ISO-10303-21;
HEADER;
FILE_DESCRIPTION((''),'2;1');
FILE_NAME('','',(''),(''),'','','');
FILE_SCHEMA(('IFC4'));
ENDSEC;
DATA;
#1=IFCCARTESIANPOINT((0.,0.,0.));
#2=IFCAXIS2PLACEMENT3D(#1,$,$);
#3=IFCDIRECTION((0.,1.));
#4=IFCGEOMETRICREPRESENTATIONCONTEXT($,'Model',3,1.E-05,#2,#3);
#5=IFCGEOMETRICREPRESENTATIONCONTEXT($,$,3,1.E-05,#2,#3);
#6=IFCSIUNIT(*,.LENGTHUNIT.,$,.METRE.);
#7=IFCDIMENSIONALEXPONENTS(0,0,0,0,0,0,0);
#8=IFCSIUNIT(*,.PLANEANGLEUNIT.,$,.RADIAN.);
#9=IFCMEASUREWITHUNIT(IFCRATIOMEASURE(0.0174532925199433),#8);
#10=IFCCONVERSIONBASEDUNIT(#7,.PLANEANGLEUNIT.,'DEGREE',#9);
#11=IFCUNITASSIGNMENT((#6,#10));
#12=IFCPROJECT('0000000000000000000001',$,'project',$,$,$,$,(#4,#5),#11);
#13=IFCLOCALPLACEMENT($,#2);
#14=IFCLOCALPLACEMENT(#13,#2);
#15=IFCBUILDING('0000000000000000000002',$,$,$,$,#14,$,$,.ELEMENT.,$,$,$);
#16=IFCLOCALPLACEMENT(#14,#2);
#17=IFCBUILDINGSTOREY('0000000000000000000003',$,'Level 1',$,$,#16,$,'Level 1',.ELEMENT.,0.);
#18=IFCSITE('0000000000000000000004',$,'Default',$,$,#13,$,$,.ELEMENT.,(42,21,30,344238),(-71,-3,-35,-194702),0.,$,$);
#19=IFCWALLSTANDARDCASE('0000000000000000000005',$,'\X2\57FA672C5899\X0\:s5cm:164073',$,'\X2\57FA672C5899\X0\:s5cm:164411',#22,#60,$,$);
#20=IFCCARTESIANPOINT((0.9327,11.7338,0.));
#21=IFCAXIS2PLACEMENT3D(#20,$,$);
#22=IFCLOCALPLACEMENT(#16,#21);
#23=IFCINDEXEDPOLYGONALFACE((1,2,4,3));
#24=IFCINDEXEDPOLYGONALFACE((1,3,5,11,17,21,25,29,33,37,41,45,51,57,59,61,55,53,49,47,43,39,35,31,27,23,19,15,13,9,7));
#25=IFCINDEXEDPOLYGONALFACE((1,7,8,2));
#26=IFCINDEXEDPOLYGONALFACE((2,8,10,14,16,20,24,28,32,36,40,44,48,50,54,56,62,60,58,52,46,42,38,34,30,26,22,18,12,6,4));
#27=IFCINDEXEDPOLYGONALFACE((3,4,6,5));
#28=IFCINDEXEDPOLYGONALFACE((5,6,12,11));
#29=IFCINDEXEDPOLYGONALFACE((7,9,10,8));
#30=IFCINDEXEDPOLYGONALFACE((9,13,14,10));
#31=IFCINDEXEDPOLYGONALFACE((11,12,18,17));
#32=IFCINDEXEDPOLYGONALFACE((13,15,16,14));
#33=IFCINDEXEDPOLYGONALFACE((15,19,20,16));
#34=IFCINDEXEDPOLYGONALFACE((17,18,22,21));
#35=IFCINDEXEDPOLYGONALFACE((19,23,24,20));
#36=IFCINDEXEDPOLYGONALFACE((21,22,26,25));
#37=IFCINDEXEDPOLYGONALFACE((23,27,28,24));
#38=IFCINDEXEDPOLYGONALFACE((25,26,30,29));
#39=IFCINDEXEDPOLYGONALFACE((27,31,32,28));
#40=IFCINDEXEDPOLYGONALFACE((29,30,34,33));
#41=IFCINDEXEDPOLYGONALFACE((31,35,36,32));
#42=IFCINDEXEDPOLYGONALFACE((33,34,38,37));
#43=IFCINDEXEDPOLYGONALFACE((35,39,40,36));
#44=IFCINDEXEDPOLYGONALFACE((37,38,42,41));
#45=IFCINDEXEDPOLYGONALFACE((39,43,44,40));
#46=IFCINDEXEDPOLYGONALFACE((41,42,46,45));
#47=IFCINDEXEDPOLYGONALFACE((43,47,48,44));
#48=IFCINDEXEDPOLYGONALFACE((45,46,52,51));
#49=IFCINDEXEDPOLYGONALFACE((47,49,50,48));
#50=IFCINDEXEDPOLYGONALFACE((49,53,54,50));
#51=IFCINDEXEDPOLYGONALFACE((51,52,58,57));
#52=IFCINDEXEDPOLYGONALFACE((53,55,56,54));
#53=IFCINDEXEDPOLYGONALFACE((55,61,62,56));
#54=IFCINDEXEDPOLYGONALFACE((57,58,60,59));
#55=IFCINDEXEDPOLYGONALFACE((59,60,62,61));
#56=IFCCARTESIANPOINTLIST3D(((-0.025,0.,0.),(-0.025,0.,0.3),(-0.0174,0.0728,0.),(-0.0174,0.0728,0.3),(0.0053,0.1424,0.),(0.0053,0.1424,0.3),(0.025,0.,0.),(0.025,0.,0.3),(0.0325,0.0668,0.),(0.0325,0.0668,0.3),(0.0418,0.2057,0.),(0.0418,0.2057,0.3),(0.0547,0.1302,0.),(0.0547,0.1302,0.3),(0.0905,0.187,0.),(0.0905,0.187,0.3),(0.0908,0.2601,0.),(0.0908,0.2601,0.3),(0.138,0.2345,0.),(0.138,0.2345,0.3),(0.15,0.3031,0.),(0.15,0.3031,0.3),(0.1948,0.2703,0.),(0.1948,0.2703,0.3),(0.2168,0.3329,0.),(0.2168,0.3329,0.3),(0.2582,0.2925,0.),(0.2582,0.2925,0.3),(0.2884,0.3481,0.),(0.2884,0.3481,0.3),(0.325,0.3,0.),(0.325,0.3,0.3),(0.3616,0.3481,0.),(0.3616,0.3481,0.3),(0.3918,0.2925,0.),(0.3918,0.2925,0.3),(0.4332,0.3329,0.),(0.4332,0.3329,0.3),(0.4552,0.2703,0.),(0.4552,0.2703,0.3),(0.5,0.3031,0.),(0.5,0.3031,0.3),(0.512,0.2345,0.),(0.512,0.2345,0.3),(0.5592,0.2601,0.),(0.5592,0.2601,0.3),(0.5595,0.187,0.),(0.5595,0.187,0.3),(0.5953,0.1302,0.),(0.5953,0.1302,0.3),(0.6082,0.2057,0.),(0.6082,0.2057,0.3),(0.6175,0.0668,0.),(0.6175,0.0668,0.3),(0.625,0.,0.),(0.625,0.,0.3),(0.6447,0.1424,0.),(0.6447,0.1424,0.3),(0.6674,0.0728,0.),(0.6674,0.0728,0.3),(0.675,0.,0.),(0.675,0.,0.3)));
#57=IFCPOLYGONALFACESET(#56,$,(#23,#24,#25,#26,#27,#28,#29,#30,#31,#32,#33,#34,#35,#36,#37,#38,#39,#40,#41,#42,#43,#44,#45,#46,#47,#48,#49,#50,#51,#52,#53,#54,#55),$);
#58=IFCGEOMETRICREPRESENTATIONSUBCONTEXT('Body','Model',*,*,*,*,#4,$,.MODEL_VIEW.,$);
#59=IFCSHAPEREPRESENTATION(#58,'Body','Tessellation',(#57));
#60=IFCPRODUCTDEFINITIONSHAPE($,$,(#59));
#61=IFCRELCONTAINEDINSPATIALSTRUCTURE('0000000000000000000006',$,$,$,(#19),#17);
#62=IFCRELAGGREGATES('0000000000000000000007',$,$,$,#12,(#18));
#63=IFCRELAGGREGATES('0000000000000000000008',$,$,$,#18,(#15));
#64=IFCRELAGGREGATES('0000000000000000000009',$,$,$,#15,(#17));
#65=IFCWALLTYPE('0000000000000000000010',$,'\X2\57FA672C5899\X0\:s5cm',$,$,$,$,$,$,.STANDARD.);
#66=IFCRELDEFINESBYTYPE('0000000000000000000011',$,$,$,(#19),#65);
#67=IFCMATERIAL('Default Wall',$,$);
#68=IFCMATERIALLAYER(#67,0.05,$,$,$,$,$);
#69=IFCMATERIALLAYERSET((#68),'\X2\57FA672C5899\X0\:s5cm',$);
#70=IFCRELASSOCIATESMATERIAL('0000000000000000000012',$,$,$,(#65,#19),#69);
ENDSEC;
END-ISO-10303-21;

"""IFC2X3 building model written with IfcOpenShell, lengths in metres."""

from ifc_helpers import new_model, entity, si_unit, converted_unit, direction, frame, frame_2d, origin, place, context, subcontext, project, spatial, polyline, circle_curve, parameter, trimmed, segment, composite_curve, outline, extrude, material, layer, layer_set, layer_usage, type_object, element, save


model = new_model("IFC2X3")

# Units and contexts
model_context = context("Model", 3, precision=1e-05, world=origin(), true_north=direction((0.0, 1.0)))
context_of_model = context(None, 3, precision=1e-05, world=origin(), true_north=direction((0.0, 1.0)))
body_context = subcontext(model_context, "Body", "Model", "MODEL_VIEW")
ifc_project = project(units=[si_unit("LENGTHUNIT", "METRE"), converted_unit("PLANEANGLEUNIT", "DEGREE", entity("IfcRatioMeasure", 0.0174532925199433), si_unit("PLANEANGLEUNIT", "RADIAN"), dimensions=[0, 0, 0, 0, 0, 0, 0])], contexts=[model_context, context_of_model])

# Site, building, storey
site_placement = place(None, origin())
site = spatial("IfcSite", under=ifc_project, at=site_placement, Name="Default", CompositionType="ELEMENT", RefLatitude=(42, 21, 30, 344238), RefLongitude=(-71, -3, -35, -194702), RefElevation=0.0)
building_placement = place(site_placement, origin())
building = spatial("IfcBuilding", under=site, at=building_placement, CompositionType="ELEMENT")
storey_placement = place(building_placement, origin())
storey = spatial("IfcBuildingStorey", under=building, at=storey_placement, Name="Level 1", LongName="Level 1", CompositionType="ELEMENT", Elevation=0.0)

# Shared definitions
ifc_material_1 = material(Name="Default Wall")

# Wall
ifc_layer_1 = layer(ifc_material_1, 0.05)
ifc_layer_set_1 = layer_set([ifc_layer_1], Name="基本墙:s5cm")
wall_type_1 = type_object("IfcWallType", Name="基本墙:s5cm", PredefinedType="STANDARD", material=ifc_layer_set_1)
ifc_layer_usage_1 = layer_usage(ifc_layer_set_1, "AXIS2", "POSITIVE", -0.025)
wall_1_placement = place(storey_placement, frame((0.9327, 11.7338, 0.0)))
element("IfcWallStandardCase", 1, at=wall_1_placement, inside=storey, type_object=wall_type_1, material=ifc_layer_usage_1, Name="基本墙:s5cm:164073", ObjectType="基本墙:s5cm:164411", context=body_context, shape_type="SweptSolid", body=[
    extrude(outline(composite_curve([segment(trimmed(circle_curve(frame_2d((0.325, 0.0), x_axis=(1.0, 0.0)), 0.35), [parameter(0.0)], [parameter(180.0)], True, "PARAMETER"), True, "CONTINUOUS"), segment(polyline([(-0.025, 0.0), (0.025, 0.0)]), True, "CONTINUOUS"), segment(trimmed(circle_curve(frame_2d((0.325, 0.0), x_axis=(1.0, 0.0)), 0.3), [parameter(0.0)], [parameter(180.0)], True, "PARAMETER"), False, "CONTINUOUS"), segment(polyline([(0.625, 0.0), (0.675, 0.0)]), True, "CONTINUOUS")], self_intersect=False)), origin(), (0.0, 0.0, 1.0), 0.3),
])

save(model, "model.ifc")
